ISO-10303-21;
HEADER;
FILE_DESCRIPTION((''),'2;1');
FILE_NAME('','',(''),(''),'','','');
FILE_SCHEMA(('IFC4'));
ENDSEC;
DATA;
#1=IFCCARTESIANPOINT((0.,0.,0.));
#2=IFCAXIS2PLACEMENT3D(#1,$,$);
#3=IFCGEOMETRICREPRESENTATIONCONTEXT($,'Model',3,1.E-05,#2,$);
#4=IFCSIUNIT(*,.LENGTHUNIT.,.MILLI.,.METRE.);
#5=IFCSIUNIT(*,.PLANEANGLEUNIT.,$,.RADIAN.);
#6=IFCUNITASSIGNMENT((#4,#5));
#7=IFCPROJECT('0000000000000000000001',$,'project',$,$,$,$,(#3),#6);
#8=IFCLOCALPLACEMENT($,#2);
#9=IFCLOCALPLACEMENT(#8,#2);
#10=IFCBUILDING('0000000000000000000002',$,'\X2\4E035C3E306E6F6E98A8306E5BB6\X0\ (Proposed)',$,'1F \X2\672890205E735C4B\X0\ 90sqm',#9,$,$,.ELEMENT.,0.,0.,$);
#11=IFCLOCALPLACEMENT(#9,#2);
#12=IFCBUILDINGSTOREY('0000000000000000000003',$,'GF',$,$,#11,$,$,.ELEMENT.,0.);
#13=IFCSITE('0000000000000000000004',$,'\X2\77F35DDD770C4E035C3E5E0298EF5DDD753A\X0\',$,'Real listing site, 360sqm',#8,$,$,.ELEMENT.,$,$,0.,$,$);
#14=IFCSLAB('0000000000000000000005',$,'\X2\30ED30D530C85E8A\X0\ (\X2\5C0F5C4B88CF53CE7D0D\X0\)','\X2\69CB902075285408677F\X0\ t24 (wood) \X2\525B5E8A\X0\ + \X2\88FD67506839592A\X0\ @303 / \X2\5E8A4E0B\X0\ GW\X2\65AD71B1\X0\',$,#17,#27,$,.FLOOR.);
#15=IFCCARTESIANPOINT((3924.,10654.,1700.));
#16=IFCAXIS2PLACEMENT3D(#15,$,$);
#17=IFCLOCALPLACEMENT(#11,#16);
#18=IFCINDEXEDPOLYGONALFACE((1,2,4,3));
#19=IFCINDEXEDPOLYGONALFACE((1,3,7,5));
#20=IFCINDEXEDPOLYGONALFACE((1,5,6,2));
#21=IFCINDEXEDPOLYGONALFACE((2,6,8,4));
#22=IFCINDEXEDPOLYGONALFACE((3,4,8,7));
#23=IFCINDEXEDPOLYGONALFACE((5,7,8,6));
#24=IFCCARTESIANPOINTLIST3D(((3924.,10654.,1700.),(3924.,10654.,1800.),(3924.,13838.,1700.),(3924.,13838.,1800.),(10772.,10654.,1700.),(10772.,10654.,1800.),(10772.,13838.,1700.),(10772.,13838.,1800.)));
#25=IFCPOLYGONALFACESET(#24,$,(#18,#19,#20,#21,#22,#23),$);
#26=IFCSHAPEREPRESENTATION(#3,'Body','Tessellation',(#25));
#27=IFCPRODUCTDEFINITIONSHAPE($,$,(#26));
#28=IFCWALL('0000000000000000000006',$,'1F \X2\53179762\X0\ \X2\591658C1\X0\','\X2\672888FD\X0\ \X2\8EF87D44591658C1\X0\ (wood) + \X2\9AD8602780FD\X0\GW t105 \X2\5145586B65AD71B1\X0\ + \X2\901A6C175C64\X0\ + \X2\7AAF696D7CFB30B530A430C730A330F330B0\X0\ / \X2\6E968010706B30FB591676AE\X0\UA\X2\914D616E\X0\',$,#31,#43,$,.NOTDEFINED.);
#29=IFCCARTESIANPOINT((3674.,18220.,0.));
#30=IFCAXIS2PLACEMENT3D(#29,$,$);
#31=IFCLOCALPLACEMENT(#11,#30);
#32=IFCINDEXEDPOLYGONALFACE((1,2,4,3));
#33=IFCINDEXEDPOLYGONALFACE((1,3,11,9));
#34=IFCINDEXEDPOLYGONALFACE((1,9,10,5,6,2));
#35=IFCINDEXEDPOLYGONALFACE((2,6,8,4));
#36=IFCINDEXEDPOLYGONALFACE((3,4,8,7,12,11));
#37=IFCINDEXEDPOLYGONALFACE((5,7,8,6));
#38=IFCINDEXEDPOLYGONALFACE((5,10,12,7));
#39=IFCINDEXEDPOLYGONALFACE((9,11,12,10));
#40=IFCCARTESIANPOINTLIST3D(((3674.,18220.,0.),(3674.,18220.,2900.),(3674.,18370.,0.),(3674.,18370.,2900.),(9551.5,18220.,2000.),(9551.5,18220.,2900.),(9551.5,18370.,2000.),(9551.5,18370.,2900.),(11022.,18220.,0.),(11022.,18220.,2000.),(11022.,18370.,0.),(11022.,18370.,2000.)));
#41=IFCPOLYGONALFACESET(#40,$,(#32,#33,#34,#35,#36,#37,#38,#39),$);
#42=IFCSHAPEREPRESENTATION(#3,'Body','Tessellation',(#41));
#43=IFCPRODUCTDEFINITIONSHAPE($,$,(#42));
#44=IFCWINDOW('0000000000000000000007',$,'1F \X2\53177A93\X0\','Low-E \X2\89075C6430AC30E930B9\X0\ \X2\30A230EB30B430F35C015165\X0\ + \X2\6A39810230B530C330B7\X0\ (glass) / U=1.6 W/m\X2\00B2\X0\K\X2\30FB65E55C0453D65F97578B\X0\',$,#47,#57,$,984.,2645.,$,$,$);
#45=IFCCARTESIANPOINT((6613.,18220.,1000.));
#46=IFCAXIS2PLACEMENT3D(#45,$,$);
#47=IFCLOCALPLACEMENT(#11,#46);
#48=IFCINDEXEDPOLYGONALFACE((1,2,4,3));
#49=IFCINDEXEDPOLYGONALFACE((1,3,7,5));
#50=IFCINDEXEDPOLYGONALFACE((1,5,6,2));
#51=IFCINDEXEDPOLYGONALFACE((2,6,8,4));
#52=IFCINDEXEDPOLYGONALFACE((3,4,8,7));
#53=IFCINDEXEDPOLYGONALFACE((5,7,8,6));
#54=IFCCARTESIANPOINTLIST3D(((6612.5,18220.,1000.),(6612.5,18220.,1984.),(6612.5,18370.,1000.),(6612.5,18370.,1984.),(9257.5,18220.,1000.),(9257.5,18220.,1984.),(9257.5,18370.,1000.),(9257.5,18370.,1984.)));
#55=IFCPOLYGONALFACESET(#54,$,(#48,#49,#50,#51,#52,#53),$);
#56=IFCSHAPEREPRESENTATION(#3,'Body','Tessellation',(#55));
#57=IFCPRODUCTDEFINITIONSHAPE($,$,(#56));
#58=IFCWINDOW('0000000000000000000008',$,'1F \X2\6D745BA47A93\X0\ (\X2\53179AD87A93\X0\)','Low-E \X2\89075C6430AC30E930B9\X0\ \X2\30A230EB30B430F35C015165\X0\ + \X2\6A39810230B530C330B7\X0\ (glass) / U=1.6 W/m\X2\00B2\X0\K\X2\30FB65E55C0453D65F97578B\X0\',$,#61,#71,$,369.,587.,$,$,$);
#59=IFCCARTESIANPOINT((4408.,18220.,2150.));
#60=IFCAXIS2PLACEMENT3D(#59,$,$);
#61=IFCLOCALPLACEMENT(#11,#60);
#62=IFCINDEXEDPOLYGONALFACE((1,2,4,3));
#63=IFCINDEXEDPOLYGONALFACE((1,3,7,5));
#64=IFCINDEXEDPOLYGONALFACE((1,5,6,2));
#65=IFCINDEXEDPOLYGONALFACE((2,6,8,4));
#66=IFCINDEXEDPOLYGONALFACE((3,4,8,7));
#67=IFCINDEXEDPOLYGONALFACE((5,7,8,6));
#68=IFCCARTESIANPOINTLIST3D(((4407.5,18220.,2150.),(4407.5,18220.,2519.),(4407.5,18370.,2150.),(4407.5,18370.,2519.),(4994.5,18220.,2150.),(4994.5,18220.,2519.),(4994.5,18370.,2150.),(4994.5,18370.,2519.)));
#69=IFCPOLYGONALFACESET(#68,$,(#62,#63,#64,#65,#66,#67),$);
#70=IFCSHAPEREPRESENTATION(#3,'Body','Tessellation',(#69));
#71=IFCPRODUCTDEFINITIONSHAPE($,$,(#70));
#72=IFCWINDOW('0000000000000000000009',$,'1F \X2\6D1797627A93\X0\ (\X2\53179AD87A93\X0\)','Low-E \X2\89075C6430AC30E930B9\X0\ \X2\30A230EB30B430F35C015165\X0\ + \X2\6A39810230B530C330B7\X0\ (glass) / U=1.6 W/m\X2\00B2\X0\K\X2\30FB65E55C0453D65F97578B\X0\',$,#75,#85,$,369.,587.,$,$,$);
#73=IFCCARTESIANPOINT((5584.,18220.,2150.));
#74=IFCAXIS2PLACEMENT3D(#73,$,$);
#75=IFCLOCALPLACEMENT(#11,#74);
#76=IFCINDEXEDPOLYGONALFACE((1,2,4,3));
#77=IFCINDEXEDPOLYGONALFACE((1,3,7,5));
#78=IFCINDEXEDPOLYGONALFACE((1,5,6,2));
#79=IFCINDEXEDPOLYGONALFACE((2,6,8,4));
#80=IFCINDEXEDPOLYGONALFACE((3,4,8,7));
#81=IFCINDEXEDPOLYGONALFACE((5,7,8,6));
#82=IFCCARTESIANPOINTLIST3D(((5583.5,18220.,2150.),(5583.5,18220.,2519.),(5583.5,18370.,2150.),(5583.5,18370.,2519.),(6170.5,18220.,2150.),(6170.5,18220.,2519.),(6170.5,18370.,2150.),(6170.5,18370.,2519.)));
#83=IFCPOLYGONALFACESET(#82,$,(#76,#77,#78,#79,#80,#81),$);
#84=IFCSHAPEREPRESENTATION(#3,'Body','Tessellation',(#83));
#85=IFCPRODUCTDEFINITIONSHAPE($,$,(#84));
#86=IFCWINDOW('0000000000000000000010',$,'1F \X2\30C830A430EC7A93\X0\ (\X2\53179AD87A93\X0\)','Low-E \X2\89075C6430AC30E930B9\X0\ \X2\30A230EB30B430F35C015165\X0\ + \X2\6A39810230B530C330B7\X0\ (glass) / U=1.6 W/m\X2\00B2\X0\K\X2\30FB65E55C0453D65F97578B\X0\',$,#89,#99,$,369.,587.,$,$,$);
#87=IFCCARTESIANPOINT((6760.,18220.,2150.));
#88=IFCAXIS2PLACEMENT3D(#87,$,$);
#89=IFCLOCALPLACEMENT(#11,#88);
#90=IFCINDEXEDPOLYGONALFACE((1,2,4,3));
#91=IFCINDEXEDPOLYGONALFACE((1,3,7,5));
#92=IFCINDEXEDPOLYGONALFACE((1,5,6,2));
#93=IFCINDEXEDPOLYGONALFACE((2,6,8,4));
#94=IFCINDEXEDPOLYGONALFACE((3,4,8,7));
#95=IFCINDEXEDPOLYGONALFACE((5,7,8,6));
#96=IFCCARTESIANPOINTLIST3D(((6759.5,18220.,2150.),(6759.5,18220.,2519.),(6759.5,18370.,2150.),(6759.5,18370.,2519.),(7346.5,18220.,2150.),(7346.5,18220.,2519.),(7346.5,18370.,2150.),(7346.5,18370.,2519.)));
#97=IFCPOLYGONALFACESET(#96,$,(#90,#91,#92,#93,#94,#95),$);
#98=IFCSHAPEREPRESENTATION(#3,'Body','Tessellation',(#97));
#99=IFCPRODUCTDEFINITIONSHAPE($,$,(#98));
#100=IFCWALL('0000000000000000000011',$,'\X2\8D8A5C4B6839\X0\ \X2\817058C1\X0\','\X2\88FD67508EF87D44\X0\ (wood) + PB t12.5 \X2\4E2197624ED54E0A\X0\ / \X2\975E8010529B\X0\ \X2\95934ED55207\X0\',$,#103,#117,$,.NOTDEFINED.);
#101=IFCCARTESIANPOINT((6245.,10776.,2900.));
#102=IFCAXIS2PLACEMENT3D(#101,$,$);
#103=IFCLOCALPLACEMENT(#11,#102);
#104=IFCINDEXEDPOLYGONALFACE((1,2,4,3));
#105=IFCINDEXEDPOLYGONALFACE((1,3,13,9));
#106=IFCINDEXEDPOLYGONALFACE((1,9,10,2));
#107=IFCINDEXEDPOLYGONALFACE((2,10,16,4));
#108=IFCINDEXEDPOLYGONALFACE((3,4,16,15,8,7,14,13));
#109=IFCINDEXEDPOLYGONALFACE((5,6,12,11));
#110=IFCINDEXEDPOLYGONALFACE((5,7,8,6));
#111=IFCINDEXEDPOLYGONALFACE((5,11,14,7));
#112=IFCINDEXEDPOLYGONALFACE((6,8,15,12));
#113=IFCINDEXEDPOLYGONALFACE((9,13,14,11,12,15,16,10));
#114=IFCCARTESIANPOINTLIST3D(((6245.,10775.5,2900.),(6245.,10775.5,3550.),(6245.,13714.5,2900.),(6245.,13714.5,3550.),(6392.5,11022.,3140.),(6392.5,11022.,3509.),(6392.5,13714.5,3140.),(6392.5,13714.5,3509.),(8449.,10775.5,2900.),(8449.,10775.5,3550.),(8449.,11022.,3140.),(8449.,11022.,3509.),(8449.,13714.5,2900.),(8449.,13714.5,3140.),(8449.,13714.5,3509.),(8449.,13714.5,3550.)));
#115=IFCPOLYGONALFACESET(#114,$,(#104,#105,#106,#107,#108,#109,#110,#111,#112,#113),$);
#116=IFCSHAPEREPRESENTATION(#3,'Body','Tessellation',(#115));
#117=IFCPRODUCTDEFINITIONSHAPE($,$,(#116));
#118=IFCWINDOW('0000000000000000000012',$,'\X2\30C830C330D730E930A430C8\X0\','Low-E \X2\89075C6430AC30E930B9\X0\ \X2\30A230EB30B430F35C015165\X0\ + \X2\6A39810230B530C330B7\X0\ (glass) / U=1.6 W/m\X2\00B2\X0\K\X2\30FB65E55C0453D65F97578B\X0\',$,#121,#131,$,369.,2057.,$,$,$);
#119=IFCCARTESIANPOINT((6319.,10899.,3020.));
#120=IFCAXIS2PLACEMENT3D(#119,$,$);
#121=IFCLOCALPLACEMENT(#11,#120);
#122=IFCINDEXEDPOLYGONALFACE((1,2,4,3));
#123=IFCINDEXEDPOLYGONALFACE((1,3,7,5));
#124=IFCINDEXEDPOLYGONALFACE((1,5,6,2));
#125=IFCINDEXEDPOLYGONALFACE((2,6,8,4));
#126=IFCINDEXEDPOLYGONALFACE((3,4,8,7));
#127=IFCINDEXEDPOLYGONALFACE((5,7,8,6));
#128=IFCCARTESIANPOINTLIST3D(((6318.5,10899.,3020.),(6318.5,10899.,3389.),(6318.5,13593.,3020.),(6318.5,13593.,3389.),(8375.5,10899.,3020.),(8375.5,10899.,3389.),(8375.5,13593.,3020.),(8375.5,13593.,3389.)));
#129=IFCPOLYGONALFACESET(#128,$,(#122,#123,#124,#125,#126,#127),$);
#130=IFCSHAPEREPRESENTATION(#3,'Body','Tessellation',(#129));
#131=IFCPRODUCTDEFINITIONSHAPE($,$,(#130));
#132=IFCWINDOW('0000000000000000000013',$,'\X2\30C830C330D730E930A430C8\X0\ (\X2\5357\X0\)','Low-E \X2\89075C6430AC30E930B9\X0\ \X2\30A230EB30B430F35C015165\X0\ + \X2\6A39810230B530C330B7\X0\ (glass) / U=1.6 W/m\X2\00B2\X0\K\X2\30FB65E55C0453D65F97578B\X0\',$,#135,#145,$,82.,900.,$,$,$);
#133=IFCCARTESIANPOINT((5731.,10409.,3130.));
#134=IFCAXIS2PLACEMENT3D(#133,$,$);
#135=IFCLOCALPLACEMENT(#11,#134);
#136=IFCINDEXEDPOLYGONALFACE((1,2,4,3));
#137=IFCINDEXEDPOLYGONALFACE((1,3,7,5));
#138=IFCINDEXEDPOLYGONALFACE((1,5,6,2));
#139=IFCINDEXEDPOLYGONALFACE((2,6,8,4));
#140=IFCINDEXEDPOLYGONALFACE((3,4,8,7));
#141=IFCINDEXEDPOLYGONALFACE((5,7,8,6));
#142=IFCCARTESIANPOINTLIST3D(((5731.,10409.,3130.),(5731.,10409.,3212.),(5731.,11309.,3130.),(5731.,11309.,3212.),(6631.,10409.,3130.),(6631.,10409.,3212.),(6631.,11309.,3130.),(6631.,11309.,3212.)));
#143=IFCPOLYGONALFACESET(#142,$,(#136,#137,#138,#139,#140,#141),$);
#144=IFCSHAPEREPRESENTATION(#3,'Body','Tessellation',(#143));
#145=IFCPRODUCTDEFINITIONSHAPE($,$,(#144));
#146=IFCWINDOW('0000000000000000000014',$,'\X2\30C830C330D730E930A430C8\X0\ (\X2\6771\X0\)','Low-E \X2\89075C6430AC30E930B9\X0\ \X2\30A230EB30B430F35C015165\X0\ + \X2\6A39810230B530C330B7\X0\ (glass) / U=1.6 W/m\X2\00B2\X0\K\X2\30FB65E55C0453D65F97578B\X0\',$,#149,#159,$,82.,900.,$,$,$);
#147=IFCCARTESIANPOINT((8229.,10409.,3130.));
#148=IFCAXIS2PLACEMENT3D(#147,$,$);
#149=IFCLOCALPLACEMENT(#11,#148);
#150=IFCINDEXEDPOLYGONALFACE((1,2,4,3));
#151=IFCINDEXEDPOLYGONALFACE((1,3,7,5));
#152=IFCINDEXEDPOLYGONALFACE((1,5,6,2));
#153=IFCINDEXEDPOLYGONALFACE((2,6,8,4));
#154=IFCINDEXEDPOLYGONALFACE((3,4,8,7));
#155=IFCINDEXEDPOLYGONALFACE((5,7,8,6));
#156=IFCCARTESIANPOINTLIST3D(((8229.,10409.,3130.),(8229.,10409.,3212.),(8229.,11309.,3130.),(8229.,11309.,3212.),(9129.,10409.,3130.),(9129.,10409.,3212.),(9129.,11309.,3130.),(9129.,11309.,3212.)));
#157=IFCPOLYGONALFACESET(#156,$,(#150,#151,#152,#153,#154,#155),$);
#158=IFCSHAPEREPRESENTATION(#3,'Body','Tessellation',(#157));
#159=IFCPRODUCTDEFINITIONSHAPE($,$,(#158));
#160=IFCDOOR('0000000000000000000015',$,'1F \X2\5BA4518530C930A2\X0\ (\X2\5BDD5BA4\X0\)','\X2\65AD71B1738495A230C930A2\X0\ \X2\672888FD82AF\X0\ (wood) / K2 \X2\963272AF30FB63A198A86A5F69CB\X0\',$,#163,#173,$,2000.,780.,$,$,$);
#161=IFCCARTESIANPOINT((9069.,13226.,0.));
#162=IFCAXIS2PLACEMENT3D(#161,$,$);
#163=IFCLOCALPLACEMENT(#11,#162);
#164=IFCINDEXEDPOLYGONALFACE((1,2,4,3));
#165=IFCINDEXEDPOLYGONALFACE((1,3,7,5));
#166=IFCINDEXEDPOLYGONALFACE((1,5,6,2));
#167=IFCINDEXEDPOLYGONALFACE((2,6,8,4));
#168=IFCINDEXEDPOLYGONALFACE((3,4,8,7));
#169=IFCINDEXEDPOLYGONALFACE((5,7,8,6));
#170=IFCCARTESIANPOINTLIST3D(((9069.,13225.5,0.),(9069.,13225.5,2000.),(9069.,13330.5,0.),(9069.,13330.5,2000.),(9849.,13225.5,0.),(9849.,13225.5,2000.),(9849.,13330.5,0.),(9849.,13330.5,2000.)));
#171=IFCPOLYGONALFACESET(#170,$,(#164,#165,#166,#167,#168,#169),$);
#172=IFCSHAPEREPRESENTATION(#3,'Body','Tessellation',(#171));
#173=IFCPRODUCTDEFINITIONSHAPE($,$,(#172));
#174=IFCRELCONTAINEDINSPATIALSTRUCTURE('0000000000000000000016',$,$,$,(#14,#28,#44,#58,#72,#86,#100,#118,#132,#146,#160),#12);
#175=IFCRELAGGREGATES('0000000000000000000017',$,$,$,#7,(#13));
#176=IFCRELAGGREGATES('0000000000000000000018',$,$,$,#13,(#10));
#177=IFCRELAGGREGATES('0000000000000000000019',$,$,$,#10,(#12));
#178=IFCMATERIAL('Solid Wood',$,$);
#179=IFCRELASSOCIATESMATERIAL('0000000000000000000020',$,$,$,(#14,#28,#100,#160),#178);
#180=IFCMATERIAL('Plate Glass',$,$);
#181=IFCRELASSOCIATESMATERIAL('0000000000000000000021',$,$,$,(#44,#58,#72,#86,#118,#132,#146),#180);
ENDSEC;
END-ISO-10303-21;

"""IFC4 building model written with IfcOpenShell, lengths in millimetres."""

from ifc_helpers import new_model, si_unit, frame, frame_2d, origin, place, context, project, spatial, rectangle, extrude, material, element, fill, save


model = new_model("IFC4")

# Units and contexts
model_context = context("Model", 3, precision=1e-05, world=origin())
ifc_project = project(units=[si_unit("LENGTHUNIT", "METRE", prefix="MILLI"), si_unit("PLANEANGLEUNIT", "RADIAN")], contexts=[model_context])

# Site, building, storey
site_placement = place(None, origin())
site = spatial("IfcSite", under=ifc_project, at=site_placement, Name="石川県七尾市飯川町", ObjectType="Real listing site, 360sqm", CompositionType="ELEMENT", RefElevation=0.0)
building_placement = place(site_placement, origin())
building = spatial("IfcBuilding", under=site, at=building_placement, Name="七尾の潮風の家 (Proposed)", ObjectType="1F 木造平屋 90sqm", CompositionType="ELEMENT", ElevationOfRefHeight=0.0, ElevationOfTerrain=0.0)
storey_placement = place(building_placement, origin())
storey = spatial("IfcBuildingStorey", under=building, at=storey_placement, Name="GF", CompositionType="ELEMENT", Elevation=0.0)

# Slab
ifc_material_1 = material(Name="Solid Wood")
slab_placement = place(storey_placement, frame((3924.0, 10654.0, 1700.0)))
element("IfcSlab", 1, at=slab_placement, inside=storey, material=ifc_material_1, Name="ロフト床 (小屋裏収納)", Description="構造用合板 t24 (wood) 剛床 + 製材根太 @303 / 床下 GW断熱", PredefinedType="FLOOR", context=model_context, shape_type="SweptSolid", body=[
    extrude(rectangle(XDim=6848.0, YDim=3184.0, at=frame_2d((3424.0, 1592.0))), frame((3924.0, 10654.0, 1700.0)), (0.0, 0.0, 1.0), 100.0),
])

# Wall, openings, windows
wall_1_placement = place(storey_placement, frame((3674.0, 18220.0, 0.0)))
wall_1 = element("IfcWall", 2, at=wall_1_placement, inside=storey, material=ifc_material_1, Name="1F 北面 外壁", Description="木製 軸組外壁 (wood) + 高性能GW t105 充填断熱 + 通気層 + 窯業系サイディング / 準耐火・外皮UA配慮", PredefinedType="NOTDEFINED", context=model_context, shape_type="SweptSolid", body=[
    extrude(rectangle(XDim=7348.0, YDim=150.0, at=frame_2d((3674.0, 75.0))), frame((3674.0, 18220.0, 0.0)), (0.0, 0.0, 1.0), 2900.0),
])
opening_1_placement = place(storey_placement, frame((6613.0, 18220.0, 1000.0)))
opening_1 = element("IfcOpeningElement", 3, at=opening_1_placement, cuts=wall_1, PredefinedType="NOTDEFINED", context=model_context, shape_type="SweptSolid", body=[
    extrude(rectangle(XDim=2645.0, YDim=150.0, at=frame_2d((1322.0, 75.0))), frame((6613.0, 18220.0, 1000.0)), (0.0, 0.0, 1.0), 984.0),
])
opening_2_placement = place(storey_placement, frame((4408.0, 18220.0, 2150.0)))
opening_2 = element("IfcOpeningElement", 4, at=opening_2_placement, cuts=wall_1, PredefinedType="NOTDEFINED", context=model_context, shape_type="SweptSolid", body=[
    extrude(rectangle(XDim=587.0, YDim=150.0, at=frame_2d((293.0, 75.0))), frame((4408.0, 18220.0, 2150.0)), (0.0, 0.0, 1.0), 369.0),
])
opening_3_placement = place(storey_placement, frame((5584.0, 18220.0, 2150.0)))
opening_3 = element("IfcOpeningElement", 5, at=opening_3_placement, cuts=wall_1, PredefinedType="NOTDEFINED", context=model_context, shape_type="SweptSolid", body=[
    extrude(rectangle(XDim=587.0, YDim=150.0, at=frame_2d((293.0, 75.0))), frame((5584.0, 18220.0, 2150.0)), (0.0, 0.0, 1.0), 369.0),
])
opening_4_placement = place(storey_placement, frame((6760.0, 18220.0, 2150.0)))
opening_4 = element("IfcOpeningElement", 6, at=opening_4_placement, cuts=wall_1, PredefinedType="NOTDEFINED", context=model_context, shape_type="SweptSolid", body=[
    extrude(rectangle(XDim=587.0, YDim=150.0, at=frame_2d((293.0, 75.0))), frame((6760.0, 18220.0, 2150.0)), (0.0, 0.0, 1.0), 369.0),
])
ifc_material_2 = material(Name="Plate Glass")
window_1_placement = place(storey_placement, frame((6613.0, 18220.0, 1000.0)))
window_1 = element("IfcWindow", 7, at=window_1_placement, inside=storey, material=ifc_material_2, Name="1F 北窓", Description="Low-E 複層ガラス アルゴン封入 + 樹脂サッシ (glass) / U=1.6 W/m²K・日射取得型", OverallHeight=984.0, OverallWidth=2645.0, context=model_context, shape_type="SweptSolid", body=[
    extrude(rectangle(XDim=2645.0, YDim=150.0, at=frame_2d((1322.0, 75.0))), frame((6613.0, 18220.0, 1000.0)), (0.0, 0.0, 1.0), 984.0),
])
fill(opening_1, window_1)
window_2_placement = place(storey_placement, frame((4408.0, 18220.0, 2150.0)))
window_2 = element("IfcWindow", 8, at=window_2_placement, inside=storey, material=ifc_material_2, Name="1F 浴室窓 (北高窓)", Description="Low-E 複層ガラス アルゴン封入 + 樹脂サッシ (glass) / U=1.6 W/m²K・日射取得型", OverallHeight=369.0, OverallWidth=587.0, context=model_context, shape_type="SweptSolid", body=[
    extrude(rectangle(XDim=587.0, YDim=150.0, at=frame_2d((293.0, 75.0))), frame((4408.0, 18220.0, 2150.0)), (0.0, 0.0, 1.0), 369.0),
])
fill(opening_2, window_2)
window_3_placement = place(storey_placement, frame((5584.0, 18220.0, 2150.0)))
window_3 = element("IfcWindow", 9, at=window_3_placement, inside=storey, material=ifc_material_2, Name="1F 洗面窓 (北高窓)", Description="Low-E 複層ガラス アルゴン封入 + 樹脂サッシ (glass) / U=1.6 W/m²K・日射取得型", OverallHeight=369.0, OverallWidth=587.0, context=model_context, shape_type="SweptSolid", body=[
    extrude(rectangle(XDim=587.0, YDim=150.0, at=frame_2d((293.0, 75.0))), frame((5584.0, 18220.0, 2150.0)), (0.0, 0.0, 1.0), 369.0),
])
fill(opening_3, window_3)
window_4_placement = place(storey_placement, frame((6760.0, 18220.0, 2150.0)))
window_4 = element("IfcWindow", 10, at=window_4_placement, inside=storey, material=ifc_material_2, Name="1F トイレ窓 (北高窓)", Description="Low-E 複層ガラス アルゴン封入 + 樹脂サッシ (glass) / U=1.6 W/m²K・日射取得型", OverallHeight=369.0, OverallWidth=587.0, context=model_context, shape_type="SweptSolid", body=[
    extrude(rectangle(XDim=587.0, YDim=150.0, at=frame_2d((293.0, 75.0))), frame((6760.0, 18220.0, 2150.0)), (0.0, 0.0, 1.0), 369.0),
])
fill(opening_4, window_4)

# Wall, openings, windows
wall_2_placement = place(storey_placement, frame((6245.0, 10776.0, 2900.0)))
wall_2 = element("IfcWall", 11, at=wall_2_placement, inside=storey, material=ifc_material_1, Name="越屋根 腰壁", Description="製材軸組 (wood) + PB t12.5 両面仕上 / 非耐力 間仕切", PredefinedType="NOTDEFINED", context=model_context, shape_type="SweptSolid", body=[
    extrude(rectangle(XDim=2204.0, YDim=2939.0, at=frame_2d((1102.0, 1469.0))), frame((6245.0, 10776.0, 2900.0)), (0.0, 0.0, 1.0), 650.0),
])
opening_5_placement = place(storey_placement, frame((6319.0, 10899.0, 3020.0)))
opening_5 = element("IfcOpeningElement", 12, at=opening_5_placement, cuts=wall_2, PredefinedType="NOTDEFINED", context=model_context, shape_type="SweptSolid", body=[
    extrude(rectangle(XDim=2057.0, YDim=2694.0, at=frame_2d((1028.0, 1347.0))), frame((6319.0, 10899.0, 3020.0)), (0.0, 0.0, 1.0), 369.0),
])
opening_6_placement = place(storey_placement, frame((5731.0, 10409.0, 3130.0)))
opening_6 = element("IfcOpeningElement", 13, at=opening_6_placement, cuts=wall_2, PredefinedType="NOTDEFINED", context=model_context, shape_type="SweptSolid", body=[
    extrude(rectangle(XDim=900.0, YDim=900.0, at=frame_2d((450.0, 450.0))), frame((5731.0, 10409.0, 3130.0)), (0.0, 0.0, 1.0), 82.0),
])
opening_7_placement = place(storey_placement, frame((8229.0, 10409.0, 3130.0)))
opening_7 = element("IfcOpeningElement", 14, at=opening_7_placement, cuts=wall_2, PredefinedType="NOTDEFINED", context=model_context, shape_type="SweptSolid", body=[
    extrude(rectangle(XDim=900.0, YDim=900.0, at=frame_2d((450.0, 450.0))), frame((8229.0, 10409.0, 3130.0)), (0.0, 0.0, 1.0), 82.0),
])
window_5_placement = place(storey_placement, frame((6319.0, 10899.0, 3020.0)))
window_5 = element("IfcWindow", 15, at=window_5_placement, inside=storey, material=ifc_material_2, Name="トップライト", Description="Low-E 複層ガラス アルゴン封入 + 樹脂サッシ (glass) / U=1.6 W/m²K・日射取得型", OverallHeight=369.0, OverallWidth=2057.0, context=model_context, shape_type="SweptSolid", body=[
    extrude(rectangle(XDim=2057.0, YDim=2694.0, at=frame_2d((1028.0, 1347.0))), frame((6319.0, 10899.0, 3020.0)), (0.0, 0.0, 1.0), 369.0),
])
fill(opening_5, window_5)
window_6_placement = place(storey_placement, frame((5731.0, 10409.0, 3130.0)))
window_6 = element("IfcWindow", 16, at=window_6_placement, inside=storey, material=ifc_material_2, Name="トップライト (南)", Description="Low-E 複層ガラス アルゴン封入 + 樹脂サッシ (glass) / U=1.6 W/m²K・日射取得型", OverallHeight=82.0, OverallWidth=900.0, context=model_context, shape_type="SweptSolid", body=[
    extrude(rectangle(XDim=900.0, YDim=900.0, at=frame_2d((450.0, 450.0))), frame((5731.0, 10409.0, 3130.0)), (0.0, 0.0, 1.0), 82.0),
])
fill(opening_6, window_6)
window_7_placement = place(storey_placement, frame((8229.0, 10409.0, 3130.0)))
window_7 = element("IfcWindow", 17, at=window_7_placement, inside=storey, material=ifc_material_2, Name="トップライト (東)", Description="Low-E 複層ガラス アルゴン封入 + 樹脂サッシ (glass) / U=1.6 W/m²K・日射取得型", OverallHeight=82.0, OverallWidth=900.0, context=model_context, shape_type="SweptSolid", body=[
    extrude(rectangle(XDim=900.0, YDim=900.0, at=frame_2d((450.0, 450.0))), frame((8229.0, 10409.0, 3130.0)), (0.0, 0.0, 1.0), 82.0),
])
fill(opening_7, window_7)

# Door
door_1_placement = place(storey_placement, frame((9069.0, 13226.0, 0.0)))
element("IfcDoor", 18, at=door_1_placement, inside=storey, material=ifc_material_1, Name="1F 室内ドア (寝室)", Description="断熱玄関ドア 木製芯 (wood) / K2 防犯・採風機構", OverallHeight=2000.0, OverallWidth=780.0, context=model_context, shape_type="SweptSolid", body=[
    extrude(rectangle(XDim=780.0, YDim=105.0, at=frame_2d((390.0, 52.0))), frame((9069.0, 13226.0, 0.0)), (0.0, 0.0, 1.0), 2000.0),
])

save(model, "model.ifc")
